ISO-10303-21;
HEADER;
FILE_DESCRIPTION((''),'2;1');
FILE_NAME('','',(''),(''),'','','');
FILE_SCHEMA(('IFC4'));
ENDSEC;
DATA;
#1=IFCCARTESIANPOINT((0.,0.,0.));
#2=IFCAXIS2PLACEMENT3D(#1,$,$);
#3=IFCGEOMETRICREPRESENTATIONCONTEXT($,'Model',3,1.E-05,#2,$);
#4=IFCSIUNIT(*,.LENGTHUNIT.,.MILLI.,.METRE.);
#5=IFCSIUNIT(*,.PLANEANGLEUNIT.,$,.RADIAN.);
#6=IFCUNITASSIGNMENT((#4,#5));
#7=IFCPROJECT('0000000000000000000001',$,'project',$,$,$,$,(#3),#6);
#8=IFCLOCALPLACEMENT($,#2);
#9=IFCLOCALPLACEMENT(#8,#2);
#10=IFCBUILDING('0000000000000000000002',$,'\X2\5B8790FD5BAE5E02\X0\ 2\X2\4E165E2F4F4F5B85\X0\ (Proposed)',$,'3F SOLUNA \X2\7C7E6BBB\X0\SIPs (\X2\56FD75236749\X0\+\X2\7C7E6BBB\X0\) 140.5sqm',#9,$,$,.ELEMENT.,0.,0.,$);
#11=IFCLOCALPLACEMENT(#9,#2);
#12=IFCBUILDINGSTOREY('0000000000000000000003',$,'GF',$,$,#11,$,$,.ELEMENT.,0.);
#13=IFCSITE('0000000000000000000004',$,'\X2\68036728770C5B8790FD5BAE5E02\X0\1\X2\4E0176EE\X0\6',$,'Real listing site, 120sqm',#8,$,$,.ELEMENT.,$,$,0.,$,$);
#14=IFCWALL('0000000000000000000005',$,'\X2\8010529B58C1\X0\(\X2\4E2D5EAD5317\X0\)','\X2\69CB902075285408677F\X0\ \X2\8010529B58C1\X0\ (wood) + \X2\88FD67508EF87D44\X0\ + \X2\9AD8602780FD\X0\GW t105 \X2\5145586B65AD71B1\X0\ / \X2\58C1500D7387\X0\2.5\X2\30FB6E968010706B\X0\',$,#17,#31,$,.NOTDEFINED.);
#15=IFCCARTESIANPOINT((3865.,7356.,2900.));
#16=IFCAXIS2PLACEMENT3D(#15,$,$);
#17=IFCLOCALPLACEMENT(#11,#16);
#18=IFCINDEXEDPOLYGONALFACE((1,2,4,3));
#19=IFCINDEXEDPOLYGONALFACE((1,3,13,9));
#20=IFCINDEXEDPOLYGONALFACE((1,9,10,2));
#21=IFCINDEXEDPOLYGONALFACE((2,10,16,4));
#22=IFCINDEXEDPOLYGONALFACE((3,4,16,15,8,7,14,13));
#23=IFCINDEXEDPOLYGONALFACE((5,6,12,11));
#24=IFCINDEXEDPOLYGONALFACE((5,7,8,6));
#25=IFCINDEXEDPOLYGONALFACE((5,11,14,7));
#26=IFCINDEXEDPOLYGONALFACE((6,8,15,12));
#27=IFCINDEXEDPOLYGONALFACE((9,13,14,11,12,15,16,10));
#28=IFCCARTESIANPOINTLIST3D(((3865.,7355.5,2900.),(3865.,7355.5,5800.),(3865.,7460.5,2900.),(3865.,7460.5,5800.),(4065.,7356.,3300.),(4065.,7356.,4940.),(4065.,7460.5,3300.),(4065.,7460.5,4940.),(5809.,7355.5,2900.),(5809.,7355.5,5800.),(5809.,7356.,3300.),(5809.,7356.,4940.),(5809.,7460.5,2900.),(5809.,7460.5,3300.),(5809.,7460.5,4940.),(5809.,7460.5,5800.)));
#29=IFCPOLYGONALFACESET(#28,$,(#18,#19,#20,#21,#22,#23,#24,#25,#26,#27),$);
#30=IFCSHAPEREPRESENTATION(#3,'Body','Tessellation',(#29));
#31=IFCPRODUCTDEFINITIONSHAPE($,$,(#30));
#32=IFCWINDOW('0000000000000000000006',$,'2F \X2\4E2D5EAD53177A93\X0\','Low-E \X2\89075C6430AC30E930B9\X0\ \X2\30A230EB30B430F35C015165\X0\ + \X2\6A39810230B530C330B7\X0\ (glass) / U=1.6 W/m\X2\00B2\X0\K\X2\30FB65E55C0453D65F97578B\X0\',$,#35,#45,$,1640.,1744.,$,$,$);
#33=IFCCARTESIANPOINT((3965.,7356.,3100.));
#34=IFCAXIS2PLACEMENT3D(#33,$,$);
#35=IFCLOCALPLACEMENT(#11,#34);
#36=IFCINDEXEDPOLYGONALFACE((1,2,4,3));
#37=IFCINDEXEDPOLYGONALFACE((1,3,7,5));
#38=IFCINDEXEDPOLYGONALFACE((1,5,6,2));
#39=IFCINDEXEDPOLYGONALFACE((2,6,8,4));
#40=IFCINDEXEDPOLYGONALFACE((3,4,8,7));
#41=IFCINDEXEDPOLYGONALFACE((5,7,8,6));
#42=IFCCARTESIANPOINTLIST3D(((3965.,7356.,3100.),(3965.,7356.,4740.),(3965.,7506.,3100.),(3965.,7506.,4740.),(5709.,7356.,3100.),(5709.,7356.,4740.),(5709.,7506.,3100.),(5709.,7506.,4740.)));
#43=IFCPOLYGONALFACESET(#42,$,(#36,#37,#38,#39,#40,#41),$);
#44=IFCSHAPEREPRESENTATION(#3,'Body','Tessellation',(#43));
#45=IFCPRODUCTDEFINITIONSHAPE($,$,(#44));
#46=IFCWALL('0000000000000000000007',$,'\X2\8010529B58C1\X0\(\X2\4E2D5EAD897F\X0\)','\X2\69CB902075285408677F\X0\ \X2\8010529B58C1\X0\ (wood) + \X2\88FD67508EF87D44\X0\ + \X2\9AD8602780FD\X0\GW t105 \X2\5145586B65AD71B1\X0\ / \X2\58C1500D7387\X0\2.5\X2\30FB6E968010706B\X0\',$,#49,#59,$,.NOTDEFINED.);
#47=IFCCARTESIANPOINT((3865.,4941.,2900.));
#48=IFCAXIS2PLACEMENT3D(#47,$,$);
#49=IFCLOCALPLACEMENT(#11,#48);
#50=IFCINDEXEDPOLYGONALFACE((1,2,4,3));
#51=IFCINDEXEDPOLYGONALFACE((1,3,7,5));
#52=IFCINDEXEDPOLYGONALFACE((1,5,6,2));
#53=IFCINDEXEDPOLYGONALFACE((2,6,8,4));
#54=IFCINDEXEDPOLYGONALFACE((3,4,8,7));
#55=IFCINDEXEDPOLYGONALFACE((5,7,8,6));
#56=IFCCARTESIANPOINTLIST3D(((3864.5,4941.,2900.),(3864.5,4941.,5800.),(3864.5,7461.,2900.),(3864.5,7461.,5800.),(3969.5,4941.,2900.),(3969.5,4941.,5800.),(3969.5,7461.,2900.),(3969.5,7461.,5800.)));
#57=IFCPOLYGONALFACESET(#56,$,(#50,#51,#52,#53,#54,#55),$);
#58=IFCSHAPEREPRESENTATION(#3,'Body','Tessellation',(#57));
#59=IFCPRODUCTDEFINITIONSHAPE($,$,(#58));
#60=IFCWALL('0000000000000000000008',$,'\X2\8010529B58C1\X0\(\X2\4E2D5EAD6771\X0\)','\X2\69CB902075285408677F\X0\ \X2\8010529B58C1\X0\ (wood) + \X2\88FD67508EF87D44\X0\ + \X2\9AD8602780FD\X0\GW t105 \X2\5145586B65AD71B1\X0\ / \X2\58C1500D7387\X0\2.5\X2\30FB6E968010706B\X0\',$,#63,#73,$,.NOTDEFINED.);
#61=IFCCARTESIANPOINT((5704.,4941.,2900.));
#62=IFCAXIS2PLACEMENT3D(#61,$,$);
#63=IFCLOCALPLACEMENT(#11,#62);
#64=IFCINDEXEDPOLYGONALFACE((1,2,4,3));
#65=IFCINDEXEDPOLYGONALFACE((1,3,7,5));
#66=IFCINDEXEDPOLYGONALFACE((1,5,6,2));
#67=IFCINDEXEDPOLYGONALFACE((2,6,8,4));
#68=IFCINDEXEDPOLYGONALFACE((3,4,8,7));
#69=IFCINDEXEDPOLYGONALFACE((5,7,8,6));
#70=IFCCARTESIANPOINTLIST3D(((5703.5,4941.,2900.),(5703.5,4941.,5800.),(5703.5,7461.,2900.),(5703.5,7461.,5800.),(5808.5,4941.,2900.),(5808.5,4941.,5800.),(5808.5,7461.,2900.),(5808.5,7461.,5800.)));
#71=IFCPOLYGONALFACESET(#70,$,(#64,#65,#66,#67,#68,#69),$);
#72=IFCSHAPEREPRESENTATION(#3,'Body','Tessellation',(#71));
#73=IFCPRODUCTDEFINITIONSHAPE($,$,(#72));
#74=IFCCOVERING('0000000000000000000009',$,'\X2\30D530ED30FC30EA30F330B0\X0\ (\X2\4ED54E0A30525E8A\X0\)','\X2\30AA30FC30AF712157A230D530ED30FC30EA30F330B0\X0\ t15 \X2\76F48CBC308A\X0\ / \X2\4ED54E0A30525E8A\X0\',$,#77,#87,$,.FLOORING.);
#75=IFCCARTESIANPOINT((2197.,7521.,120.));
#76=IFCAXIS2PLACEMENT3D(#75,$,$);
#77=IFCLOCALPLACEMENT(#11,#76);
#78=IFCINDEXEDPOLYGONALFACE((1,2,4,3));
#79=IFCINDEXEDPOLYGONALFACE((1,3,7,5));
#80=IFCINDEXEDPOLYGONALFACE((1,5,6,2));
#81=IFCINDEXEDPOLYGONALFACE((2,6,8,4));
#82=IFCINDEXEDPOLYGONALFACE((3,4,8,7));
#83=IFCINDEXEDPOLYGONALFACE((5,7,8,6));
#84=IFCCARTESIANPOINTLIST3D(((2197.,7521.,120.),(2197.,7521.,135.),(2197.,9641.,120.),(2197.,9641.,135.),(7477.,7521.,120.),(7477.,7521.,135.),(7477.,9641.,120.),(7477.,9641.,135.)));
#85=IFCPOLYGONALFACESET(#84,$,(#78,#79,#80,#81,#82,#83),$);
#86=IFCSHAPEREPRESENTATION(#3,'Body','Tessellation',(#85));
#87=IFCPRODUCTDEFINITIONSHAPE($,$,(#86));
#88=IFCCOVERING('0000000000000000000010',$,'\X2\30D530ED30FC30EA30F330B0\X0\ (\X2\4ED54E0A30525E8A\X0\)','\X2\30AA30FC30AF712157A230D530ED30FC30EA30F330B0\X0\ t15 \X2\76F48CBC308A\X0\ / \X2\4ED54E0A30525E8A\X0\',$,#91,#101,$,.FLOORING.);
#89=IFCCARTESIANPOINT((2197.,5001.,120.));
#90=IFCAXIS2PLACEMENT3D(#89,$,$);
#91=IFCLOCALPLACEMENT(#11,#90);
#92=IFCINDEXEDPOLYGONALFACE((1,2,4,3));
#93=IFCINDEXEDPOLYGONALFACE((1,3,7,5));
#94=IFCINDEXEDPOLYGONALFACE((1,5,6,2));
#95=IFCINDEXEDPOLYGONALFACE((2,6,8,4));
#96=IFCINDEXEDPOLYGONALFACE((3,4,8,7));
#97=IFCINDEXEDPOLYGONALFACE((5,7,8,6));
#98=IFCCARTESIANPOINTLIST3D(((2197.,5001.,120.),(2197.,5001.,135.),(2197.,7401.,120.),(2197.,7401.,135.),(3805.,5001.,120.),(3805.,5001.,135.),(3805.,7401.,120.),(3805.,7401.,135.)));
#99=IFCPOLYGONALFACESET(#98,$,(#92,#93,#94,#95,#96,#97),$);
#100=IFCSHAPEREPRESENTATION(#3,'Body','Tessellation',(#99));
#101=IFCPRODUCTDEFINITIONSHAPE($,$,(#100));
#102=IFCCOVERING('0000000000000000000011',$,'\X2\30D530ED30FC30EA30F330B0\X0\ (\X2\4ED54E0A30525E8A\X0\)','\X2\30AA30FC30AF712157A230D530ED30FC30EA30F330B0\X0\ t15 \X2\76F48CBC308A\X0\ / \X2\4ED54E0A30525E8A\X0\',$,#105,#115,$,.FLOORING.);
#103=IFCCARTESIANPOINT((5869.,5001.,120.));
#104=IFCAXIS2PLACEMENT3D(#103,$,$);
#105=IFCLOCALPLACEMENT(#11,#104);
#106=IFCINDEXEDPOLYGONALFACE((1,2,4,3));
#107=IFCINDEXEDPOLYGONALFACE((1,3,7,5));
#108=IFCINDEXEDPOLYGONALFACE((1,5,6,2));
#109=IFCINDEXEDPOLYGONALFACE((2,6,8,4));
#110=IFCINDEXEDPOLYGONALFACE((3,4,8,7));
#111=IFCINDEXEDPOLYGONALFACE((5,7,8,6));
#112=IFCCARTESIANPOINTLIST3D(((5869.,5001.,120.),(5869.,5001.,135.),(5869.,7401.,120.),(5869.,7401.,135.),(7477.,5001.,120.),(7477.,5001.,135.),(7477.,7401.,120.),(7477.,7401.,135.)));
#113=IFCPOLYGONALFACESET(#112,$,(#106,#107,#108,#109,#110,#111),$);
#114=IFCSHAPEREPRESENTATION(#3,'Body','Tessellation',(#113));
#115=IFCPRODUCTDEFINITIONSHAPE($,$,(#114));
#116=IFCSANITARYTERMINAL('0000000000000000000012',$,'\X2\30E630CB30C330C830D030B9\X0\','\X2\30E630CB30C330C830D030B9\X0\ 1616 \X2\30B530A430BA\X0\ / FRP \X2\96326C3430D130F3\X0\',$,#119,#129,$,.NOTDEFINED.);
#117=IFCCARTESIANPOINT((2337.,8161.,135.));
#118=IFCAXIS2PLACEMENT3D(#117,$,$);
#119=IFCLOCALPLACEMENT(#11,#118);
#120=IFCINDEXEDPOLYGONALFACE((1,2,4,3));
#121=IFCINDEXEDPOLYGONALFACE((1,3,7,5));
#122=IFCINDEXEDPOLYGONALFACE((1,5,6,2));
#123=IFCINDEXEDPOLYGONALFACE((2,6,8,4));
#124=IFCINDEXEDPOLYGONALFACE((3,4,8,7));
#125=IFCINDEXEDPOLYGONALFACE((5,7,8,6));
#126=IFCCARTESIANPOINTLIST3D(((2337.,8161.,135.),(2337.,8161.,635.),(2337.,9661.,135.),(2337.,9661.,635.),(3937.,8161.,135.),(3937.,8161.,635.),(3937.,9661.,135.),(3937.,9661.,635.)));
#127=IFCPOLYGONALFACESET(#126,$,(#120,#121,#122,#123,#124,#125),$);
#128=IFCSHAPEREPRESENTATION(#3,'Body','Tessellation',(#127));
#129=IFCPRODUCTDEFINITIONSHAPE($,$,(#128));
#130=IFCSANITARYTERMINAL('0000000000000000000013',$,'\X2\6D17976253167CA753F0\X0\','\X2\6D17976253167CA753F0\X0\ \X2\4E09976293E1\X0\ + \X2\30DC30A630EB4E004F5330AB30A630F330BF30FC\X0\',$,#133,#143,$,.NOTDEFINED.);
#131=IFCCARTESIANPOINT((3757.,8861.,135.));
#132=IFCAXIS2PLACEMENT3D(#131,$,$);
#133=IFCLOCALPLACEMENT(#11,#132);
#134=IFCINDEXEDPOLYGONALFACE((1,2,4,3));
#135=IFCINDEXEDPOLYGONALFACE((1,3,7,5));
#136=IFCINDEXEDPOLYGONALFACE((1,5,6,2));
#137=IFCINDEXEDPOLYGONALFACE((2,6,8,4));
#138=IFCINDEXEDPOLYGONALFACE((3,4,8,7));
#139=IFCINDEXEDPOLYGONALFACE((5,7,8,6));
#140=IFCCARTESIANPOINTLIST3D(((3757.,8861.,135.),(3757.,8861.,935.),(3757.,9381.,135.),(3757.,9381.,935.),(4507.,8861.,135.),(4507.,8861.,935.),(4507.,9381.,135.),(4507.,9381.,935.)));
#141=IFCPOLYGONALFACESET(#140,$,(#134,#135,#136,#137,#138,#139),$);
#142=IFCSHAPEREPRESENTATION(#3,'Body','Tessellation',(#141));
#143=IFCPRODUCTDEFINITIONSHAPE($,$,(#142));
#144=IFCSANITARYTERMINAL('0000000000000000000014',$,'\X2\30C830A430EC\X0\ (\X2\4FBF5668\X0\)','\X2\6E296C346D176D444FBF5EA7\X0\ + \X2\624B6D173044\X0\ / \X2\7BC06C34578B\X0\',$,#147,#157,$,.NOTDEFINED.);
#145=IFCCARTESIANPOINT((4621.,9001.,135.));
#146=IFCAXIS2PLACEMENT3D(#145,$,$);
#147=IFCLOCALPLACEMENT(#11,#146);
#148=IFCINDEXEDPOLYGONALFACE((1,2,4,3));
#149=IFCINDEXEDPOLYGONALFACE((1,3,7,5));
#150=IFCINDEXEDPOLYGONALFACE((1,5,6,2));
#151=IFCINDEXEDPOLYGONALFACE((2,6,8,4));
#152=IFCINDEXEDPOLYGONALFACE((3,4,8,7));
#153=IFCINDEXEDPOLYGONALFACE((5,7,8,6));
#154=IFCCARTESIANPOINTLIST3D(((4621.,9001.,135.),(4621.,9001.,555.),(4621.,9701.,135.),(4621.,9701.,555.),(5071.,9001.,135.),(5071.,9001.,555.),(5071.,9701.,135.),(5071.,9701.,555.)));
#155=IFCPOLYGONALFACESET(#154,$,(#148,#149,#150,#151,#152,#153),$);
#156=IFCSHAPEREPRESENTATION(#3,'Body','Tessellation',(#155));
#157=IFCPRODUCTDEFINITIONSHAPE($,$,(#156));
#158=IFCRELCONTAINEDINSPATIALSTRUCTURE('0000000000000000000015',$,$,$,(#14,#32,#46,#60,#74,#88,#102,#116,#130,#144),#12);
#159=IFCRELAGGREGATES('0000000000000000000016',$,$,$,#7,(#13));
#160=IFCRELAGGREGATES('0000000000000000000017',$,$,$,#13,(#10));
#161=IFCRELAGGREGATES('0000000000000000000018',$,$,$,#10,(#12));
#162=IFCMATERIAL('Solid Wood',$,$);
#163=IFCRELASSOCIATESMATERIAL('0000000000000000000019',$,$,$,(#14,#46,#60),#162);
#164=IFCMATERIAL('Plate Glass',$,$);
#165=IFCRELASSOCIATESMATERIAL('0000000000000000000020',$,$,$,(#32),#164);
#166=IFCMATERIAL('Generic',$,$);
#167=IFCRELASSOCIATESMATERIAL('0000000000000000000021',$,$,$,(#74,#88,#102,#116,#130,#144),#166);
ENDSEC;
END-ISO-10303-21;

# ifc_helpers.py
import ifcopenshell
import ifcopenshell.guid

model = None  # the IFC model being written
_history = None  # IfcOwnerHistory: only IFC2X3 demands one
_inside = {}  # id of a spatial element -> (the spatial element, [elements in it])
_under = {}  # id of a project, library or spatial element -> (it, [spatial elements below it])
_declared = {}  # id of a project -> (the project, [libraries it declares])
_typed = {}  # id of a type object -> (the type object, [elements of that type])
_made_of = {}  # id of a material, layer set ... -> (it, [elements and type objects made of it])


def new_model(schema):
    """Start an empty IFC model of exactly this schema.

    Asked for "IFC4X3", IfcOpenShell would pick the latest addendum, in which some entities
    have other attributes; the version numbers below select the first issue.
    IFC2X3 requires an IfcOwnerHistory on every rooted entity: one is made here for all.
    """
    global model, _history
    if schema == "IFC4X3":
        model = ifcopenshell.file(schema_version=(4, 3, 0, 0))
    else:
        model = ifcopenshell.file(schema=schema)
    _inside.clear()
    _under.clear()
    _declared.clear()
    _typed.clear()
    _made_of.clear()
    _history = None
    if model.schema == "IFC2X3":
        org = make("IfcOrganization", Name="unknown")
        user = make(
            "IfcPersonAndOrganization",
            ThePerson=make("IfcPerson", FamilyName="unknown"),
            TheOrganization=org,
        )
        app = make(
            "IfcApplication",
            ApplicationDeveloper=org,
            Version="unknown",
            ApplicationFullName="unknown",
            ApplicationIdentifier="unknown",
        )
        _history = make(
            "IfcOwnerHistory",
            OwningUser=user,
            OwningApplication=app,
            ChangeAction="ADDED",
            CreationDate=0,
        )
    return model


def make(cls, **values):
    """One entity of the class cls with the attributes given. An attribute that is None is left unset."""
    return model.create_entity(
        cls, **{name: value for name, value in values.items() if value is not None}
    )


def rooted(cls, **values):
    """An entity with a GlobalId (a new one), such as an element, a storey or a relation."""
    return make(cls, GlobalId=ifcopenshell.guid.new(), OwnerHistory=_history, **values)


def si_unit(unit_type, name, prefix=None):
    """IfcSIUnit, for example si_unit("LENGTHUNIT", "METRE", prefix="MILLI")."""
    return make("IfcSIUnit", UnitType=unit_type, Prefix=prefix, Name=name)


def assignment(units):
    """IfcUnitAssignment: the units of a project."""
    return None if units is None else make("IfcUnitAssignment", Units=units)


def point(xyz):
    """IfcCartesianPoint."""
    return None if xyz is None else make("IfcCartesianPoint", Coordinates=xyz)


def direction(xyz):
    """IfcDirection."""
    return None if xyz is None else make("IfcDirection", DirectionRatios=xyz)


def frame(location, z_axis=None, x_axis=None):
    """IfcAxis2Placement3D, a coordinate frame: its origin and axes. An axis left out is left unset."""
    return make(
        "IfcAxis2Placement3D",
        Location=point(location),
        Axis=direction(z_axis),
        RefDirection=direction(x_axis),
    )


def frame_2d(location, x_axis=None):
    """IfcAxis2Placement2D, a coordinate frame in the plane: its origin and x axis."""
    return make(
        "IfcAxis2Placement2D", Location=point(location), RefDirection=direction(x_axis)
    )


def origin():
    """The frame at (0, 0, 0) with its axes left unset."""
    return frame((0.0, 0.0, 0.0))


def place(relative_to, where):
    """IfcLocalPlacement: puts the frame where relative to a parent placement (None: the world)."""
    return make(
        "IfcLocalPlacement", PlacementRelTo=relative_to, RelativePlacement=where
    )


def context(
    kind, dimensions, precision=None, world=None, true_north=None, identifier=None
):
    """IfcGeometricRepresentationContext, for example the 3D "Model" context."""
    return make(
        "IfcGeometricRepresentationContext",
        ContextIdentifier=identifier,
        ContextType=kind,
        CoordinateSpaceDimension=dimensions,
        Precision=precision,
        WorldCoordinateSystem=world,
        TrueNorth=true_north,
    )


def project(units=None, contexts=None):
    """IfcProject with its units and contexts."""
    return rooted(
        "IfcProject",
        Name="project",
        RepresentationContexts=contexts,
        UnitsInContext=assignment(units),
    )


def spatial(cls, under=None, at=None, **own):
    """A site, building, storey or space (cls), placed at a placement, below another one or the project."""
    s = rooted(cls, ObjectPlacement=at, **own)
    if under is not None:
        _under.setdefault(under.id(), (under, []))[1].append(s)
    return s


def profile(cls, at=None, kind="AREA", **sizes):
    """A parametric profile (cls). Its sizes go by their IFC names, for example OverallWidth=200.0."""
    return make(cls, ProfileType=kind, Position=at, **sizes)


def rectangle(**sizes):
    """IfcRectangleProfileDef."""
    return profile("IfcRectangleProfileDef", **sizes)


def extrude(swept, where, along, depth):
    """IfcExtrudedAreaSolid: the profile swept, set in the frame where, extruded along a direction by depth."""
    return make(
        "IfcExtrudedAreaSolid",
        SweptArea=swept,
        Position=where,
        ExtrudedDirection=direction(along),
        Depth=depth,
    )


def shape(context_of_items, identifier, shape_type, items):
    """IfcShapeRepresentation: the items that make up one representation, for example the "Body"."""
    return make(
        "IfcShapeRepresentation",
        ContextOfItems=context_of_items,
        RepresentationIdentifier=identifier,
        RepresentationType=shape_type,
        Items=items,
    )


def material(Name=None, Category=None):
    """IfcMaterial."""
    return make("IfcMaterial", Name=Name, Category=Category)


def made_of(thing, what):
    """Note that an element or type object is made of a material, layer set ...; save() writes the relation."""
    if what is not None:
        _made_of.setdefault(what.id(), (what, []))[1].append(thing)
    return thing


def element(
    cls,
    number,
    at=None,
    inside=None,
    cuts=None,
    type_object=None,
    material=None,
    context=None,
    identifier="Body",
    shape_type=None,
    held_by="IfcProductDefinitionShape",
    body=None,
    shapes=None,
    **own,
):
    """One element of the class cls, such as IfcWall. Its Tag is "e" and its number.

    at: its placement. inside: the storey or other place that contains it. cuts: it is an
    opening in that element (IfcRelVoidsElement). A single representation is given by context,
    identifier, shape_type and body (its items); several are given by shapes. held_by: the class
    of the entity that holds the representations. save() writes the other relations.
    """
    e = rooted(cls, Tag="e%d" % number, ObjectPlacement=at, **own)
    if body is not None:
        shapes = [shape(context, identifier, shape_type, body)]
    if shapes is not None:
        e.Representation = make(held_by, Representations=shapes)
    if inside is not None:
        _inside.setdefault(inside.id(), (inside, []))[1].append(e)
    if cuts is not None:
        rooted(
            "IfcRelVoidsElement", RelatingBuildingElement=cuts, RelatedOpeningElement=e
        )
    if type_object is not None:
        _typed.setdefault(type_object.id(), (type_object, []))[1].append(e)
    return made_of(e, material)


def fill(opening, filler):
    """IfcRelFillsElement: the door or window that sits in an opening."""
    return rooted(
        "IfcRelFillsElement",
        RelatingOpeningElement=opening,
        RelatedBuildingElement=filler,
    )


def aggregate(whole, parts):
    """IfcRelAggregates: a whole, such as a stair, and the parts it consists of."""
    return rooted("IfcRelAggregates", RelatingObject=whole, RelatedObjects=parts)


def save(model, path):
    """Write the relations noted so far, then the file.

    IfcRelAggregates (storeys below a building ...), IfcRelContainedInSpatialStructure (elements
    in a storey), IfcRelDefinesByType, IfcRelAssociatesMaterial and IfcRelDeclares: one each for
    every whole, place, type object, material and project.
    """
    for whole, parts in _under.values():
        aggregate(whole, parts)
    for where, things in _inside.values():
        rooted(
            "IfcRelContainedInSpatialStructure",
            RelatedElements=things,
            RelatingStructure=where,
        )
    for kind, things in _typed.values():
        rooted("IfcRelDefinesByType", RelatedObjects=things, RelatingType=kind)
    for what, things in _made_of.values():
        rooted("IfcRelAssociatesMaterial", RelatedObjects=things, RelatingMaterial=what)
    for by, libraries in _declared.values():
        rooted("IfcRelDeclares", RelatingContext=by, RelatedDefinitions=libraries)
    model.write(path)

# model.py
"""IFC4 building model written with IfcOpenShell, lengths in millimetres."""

from ifc_helpers import new_model, si_unit, frame, frame_2d, origin, place, context, project, spatial, rectangle, extrude, material, element, fill, save


model = new_model("IFC4")

# Units and contexts
model_context = context("Model", 3, precision=1e-05, world=origin())
ifc_project = project(units=[si_unit("LENGTHUNIT", "METRE", prefix="MILLI"), si_unit("PLANEANGLEUNIT", "RADIAN")], contexts=[model_context])

# Site, building, storey
site_placement = place(None, origin())
site = spatial("IfcSite", under=ifc_project, at=site_placement, Name="栃木県宇都宮市1丁目6", ObjectType="Real listing site, 120sqm", CompositionType="ELEMENT", RefElevation=0.0)
building_placement = place(site_placement, origin())
building = spatial("IfcBuilding", under=site, at=building_placement, Name="宇都宮市 2世帯住宅 (Proposed)", ObjectType="3F SOLUNA 籾殻SIPs (国産杉+籾殻) 140.5sqm", CompositionType="ELEMENT", ElevationOfRefHeight=0.0, ElevationOfTerrain=0.0)
storey_placement = place(building_placement, origin())
storey = spatial("IfcBuildingStorey", under=building, at=storey_placement, Name="GF", CompositionType="ELEMENT", Elevation=0.0)

# Shared definitions
ifc_material_1 = material(Name="Solid Wood")

# Shared definitions
ifc_material_2 = material(Name="Plate Glass")

# Wall, opening, window
wall_1_placement = place(storey_placement, frame((3865.0, 7356.0, 2900.0)))
wall_1 = element("IfcWall", 1, at=wall_1_placement, inside=storey, material=ifc_material_1, Name="耐力壁(中庭北)", Description="構造用合板 耐力壁 (wood) + 製材軸組 + 高性能GW t105 充填断熱 / 壁倍率2.5・準耐火", PredefinedType="NOTDEFINED", context=model_context, shape_type="SweptSolid", body=[
    extrude(rectangle(XDim=1944.0, YDim=105.0, at=frame_2d((972.0, 52.0))), frame((3865.0, 7356.0, 2900.0)), (0.0, 0.0, 1.0), 2900.0),
])
opening_1_placement = place(storey_placement, frame((3965.0, 7356.0, 3100.0)))
opening_1 = element("IfcOpeningElement", 2, at=opening_1_placement, cuts=wall_1, PredefinedType="NOTDEFINED", context=model_context, shape_type="SweptSolid", body=[
    extrude(rectangle(XDim=1744.0, YDim=150.0, at=frame_2d((872.0, 75.0))), frame((3965.0, 7356.0, 3100.0)), (0.0, 0.0, 1.0), 1640.0),
])
window_1_placement = place(storey_placement, frame((3965.0, 7356.0, 3100.0)))
window_1 = element("IfcWindow", 3, at=window_1_placement, inside=storey, material=ifc_material_2, Name="2F 中庭北窓", Description="Low-E 複層ガラス アルゴン封入 + 樹脂サッシ (glass) / U=1.6 W/m²K・日射取得型", OverallHeight=1640.0, OverallWidth=1744.0, context=model_context, shape_type="SweptSolid", body=[
    extrude(rectangle(XDim=1744.0, YDim=150.0, at=frame_2d((872.0, 75.0))), frame((3965.0, 7356.0, 3100.0)), (0.0, 0.0, 1.0), 1640.0),
])
fill(opening_1, window_1)

# Walls
wall_2_placement = place(storey_placement, frame((3865.0, 4941.0, 2900.0)))
element("IfcWall", 4, at=wall_2_placement, inside=storey, material=ifc_material_1, Name="耐力壁(中庭西)", Description="構造用合板 耐力壁 (wood) + 製材軸組 + 高性能GW t105 充填断熱 / 壁倍率2.5・準耐火", PredefinedType="NOTDEFINED", context=model_context, shape_type="SweptSolid", body=[
    extrude(rectangle(XDim=105.0, YDim=2520.0, at=frame_2d((52.0, 1260.0))), frame((3865.0, 4941.0, 2900.0)), (0.0, 0.0, 1.0), 2900.0),
])
wall_3_placement = place(storey_placement, frame((5704.0, 4941.0, 2900.0)))
element("IfcWall", 5, at=wall_3_placement, inside=storey, material=ifc_material_1, Name="耐力壁(中庭東)", Description="構造用合板 耐力壁 (wood) + 製材軸組 + 高性能GW t105 充填断熱 / 壁倍率2.5・準耐火", PredefinedType="NOTDEFINED", context=model_context, shape_type="SweptSolid", body=[
    extrude(rectangle(XDim=105.0, YDim=2520.0, at=frame_2d((52.0, 1260.0))), frame((5704.0, 4941.0, 2900.0)), (0.0, 0.0, 1.0), 2900.0),
])

# Coverings
ifc_material_3 = material(Name="Generic")
covering_1_placement = place(storey_placement, frame((2197.0, 7521.0, 120.0)))
element("IfcCovering", 6, at=covering_1_placement, inside=storey, material=ifc_material_3, Name="フローリング (仕上げ床)", Description="オーク無垢フローリング t15 直貼り / 仕上げ床", PredefinedType="FLOORING", context=model_context, shape_type="SweptSolid", body=[
    extrude(rectangle(XDim=5280.0, YDim=2120.0, at=frame_2d((2640.0, 1060.0))), frame((2197.0, 7521.0, 120.0)), (0.0, 0.0, 1.0), 15.0),
])
covering_2_placement = place(storey_placement, frame((2197.0, 5001.0, 120.0)))
element("IfcCovering", 7, at=covering_2_placement, inside=storey, material=ifc_material_3, Name="フローリング (仕上げ床)", Description="オーク無垢フローリング t15 直貼り / 仕上げ床", PredefinedType="FLOORING", context=model_context, shape_type="SweptSolid", body=[
    extrude(rectangle(XDim=1608.0, YDim=2400.0, at=frame_2d((804.0, 1200.0))), frame((2197.0, 5001.0, 120.0)), (0.0, 0.0, 1.0), 15.0),
])
covering_3_placement = place(storey_placement, frame((5869.0, 5001.0, 120.0)))
element("IfcCovering", 8, at=covering_3_placement, inside=storey, material=ifc_material_3, Name="フローリング (仕上げ床)", Description="オーク無垢フローリング t15 直貼り / 仕上げ床", PredefinedType="FLOORING", context=model_context, shape_type="SweptSolid", body=[
    extrude(rectangle(XDim=1608.0, YDim=2400.0, at=frame_2d((804.0, 1200.0))), frame((5869.0, 5001.0, 120.0)), (0.0, 0.0, 1.0), 15.0),
])

# Sanitary terminals
sanitary_terminal_1_placement = place(storey_placement, frame((2337.0, 8161.0, 135.0)))
element("IfcSanitaryTerminal", 9, at=sanitary_terminal_1_placement, inside=storey, material=ifc_material_3, Name="ユニットバス", Description="ユニットバス 1616 サイズ / FRP 防水パン", PredefinedType="NOTDEFINED", context=model_context, shape_type="SweptSolid", body=[
    extrude(rectangle(XDim=1600.0, YDim=1500.0, at=frame_2d((800.0, 750.0))), frame((2337.0, 8161.0, 135.0)), (0.0, 0.0, 1.0), 500.0),
])
sanitary_terminal_2_placement = place(storey_placement, frame((3757.0, 8861.0, 135.0)))
element("IfcSanitaryTerminal", 10, at=sanitary_terminal_2_placement, inside=storey, material=ifc_material_3, Name="洗面化粧台", Description="洗面化粧台 三面鏡 + ボウル一体カウンター", PredefinedType="NOTDEFINED", context=model_context, shape_type="SweptSolid", body=[
    extrude(rectangle(XDim=750.0, YDim=520.0, at=frame_2d((375.0, 260.0))), frame((3757.0, 8861.0, 135.0)), (0.0, 0.0, 1.0), 800.0),
])
sanitary_terminal_3_placement = place(storey_placement, frame((4621.0, 9001.0, 135.0)))
element("IfcSanitaryTerminal", 11, at=sanitary_terminal_3_placement, inside=storey, material=ifc_material_3, Name="トイレ (便器)", Description="温水洗浄便座 + 手洗い / 節水型", PredefinedType="NOTDEFINED", context=model_context, shape_type="SweptSolid", body=[
    extrude(rectangle(XDim=450.0, YDim=700.0, at=frame_2d((225.0, 350.0))), frame((4621.0, 9001.0, 135.0)), (0.0, 0.0, 1.0), 420.0),
])

save(model, "model.ifc")
